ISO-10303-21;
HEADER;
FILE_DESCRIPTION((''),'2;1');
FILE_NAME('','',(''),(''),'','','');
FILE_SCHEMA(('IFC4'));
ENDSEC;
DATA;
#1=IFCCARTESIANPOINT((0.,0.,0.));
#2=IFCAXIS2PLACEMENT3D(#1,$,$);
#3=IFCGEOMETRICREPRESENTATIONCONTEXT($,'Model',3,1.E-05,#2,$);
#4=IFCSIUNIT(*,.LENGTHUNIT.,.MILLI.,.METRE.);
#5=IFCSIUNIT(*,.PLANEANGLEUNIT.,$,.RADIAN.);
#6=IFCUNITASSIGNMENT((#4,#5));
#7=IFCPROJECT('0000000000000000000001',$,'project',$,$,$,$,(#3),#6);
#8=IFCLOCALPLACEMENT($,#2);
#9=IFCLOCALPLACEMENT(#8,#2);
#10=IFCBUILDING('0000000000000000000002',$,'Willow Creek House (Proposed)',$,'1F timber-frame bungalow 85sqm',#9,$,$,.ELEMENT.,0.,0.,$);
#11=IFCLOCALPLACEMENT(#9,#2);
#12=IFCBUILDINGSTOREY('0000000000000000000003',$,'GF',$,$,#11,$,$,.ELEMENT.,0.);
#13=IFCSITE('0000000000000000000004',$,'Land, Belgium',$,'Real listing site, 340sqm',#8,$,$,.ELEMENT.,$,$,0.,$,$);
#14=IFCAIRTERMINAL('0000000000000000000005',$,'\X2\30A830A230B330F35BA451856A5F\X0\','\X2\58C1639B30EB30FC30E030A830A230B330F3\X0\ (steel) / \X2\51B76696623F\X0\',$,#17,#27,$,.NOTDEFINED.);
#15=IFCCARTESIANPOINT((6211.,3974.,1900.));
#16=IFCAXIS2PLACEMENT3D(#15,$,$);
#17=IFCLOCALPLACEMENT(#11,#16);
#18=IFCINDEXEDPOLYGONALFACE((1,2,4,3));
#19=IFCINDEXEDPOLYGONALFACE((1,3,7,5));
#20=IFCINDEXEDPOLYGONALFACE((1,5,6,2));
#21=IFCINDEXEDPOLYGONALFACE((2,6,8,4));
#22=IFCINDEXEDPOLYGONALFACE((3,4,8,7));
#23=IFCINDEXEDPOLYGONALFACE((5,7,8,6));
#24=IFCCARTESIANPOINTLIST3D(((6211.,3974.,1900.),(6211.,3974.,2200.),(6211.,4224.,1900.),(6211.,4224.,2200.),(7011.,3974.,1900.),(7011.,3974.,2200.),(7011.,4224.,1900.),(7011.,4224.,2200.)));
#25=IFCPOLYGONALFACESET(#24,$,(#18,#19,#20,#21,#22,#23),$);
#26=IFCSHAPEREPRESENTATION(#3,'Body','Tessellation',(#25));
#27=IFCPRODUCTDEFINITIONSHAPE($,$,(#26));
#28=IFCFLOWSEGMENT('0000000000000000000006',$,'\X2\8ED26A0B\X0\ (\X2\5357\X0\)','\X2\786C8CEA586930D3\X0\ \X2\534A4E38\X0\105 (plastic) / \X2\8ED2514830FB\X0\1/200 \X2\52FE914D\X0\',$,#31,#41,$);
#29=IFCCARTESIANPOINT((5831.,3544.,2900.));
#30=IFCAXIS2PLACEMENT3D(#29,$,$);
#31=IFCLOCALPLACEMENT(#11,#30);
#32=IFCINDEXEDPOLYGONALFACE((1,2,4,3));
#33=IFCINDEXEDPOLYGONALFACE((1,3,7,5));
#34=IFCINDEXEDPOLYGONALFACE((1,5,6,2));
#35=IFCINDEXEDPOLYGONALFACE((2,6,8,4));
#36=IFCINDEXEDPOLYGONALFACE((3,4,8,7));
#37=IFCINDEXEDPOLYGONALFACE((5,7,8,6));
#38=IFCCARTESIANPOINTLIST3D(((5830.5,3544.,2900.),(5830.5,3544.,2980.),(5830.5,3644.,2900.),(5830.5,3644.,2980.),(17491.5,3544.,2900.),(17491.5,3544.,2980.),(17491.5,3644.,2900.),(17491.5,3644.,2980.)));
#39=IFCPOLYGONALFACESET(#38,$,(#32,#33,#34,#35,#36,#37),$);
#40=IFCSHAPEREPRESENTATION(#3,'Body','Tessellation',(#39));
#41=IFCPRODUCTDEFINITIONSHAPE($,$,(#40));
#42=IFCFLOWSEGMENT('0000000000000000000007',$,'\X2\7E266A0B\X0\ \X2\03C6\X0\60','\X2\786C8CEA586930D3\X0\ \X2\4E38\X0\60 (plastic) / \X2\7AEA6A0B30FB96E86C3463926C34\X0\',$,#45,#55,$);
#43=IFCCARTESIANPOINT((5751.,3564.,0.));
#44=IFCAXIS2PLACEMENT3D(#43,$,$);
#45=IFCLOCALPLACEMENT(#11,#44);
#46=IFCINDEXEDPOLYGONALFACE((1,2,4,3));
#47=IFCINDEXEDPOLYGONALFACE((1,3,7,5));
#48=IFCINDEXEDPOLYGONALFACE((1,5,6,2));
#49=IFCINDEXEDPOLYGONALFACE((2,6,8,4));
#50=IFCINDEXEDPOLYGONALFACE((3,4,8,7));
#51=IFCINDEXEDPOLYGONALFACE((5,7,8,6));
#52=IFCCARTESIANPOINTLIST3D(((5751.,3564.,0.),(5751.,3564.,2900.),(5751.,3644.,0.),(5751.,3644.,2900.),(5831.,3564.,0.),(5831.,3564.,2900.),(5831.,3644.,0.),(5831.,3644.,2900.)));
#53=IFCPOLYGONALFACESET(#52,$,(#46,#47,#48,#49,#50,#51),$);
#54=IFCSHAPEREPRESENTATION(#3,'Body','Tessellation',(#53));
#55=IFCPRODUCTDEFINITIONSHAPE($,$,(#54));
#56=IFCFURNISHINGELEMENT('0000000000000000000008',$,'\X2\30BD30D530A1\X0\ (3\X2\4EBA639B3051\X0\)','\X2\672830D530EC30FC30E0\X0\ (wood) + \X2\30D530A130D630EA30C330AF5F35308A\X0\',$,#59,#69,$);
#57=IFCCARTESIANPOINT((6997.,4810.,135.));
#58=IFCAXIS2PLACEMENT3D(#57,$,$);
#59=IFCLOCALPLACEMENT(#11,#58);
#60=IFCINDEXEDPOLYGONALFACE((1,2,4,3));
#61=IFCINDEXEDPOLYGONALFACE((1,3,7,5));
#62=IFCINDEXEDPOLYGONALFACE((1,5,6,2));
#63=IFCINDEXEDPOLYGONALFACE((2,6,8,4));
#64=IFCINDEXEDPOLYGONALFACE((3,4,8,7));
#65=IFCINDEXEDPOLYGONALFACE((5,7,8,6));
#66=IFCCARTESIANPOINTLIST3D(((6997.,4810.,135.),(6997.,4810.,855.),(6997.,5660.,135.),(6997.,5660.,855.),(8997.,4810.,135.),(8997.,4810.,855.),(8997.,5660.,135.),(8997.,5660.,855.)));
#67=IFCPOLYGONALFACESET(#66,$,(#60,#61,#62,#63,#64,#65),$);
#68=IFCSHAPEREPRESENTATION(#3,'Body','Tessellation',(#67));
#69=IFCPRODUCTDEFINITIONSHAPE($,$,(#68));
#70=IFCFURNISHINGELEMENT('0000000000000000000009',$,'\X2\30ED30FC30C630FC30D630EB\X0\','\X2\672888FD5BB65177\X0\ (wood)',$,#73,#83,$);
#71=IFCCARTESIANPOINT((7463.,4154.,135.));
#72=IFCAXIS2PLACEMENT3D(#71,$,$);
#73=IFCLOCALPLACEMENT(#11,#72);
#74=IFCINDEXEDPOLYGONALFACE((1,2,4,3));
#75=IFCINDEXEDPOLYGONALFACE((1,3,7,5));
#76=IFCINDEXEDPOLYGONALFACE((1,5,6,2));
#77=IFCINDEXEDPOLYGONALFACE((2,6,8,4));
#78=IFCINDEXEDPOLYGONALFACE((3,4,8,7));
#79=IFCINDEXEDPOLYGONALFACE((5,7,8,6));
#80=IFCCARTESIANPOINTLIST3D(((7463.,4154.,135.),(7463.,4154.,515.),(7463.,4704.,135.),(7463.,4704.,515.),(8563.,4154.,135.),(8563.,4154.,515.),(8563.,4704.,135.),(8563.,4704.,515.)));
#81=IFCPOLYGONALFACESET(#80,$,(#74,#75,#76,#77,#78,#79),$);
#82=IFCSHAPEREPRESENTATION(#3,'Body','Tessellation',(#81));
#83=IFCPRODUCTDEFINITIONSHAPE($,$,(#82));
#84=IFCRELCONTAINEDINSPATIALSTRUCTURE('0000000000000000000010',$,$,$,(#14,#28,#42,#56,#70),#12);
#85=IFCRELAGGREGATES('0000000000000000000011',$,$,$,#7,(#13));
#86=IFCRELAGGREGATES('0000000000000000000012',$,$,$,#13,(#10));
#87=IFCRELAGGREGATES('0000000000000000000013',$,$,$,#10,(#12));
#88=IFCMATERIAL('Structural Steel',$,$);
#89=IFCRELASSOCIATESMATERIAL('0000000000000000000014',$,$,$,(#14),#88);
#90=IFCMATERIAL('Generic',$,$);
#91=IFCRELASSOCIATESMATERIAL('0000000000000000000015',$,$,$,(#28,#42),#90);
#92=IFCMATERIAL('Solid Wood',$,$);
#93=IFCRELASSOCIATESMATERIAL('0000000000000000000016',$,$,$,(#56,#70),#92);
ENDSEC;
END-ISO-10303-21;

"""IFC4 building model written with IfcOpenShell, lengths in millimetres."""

from ifc_helpers import new_model, si_unit, frame, frame_2d, origin, place, context, project, spatial, rectangle, extrude, material, element, save


model = new_model("IFC4")

# Units and contexts
model_context = context("Model", 3, precision=1e-05, world=origin())
ifc_project = project(units=[si_unit("LENGTHUNIT", "METRE", prefix="MILLI"), si_unit("PLANEANGLEUNIT", "RADIAN")], contexts=[model_context])

# Site, building, storey
site_placement = place(None, origin())
site = spatial("IfcSite", under=ifc_project, at=site_placement, Name="Land, Belgium", ObjectType="Real listing site, 340sqm", CompositionType="ELEMENT", RefElevation=0.0)
building_placement = place(site_placement, origin())
building = spatial("IfcBuilding", under=site, at=building_placement, Name="Willow Creek House (Proposed)", ObjectType="1F timber-frame bungalow 85sqm", CompositionType="ELEMENT", ElevationOfRefHeight=0.0, ElevationOfTerrain=0.0)
storey_placement = place(building_placement, origin())
storey = spatial("IfcBuildingStorey", under=building, at=storey_placement, Name="GF", CompositionType="ELEMENT", Elevation=0.0)

# Shared definitions
ifc_material_1 = material(Name="Solid Wood")

# Shared definitions
ifc_material_2 = material(Name="Structural Steel")

# Shared definitions
ifc_material_3 = material(Name="Generic")

# Air terminal
air_terminal_placement = place(storey_placement, frame((6211.0, 3974.0, 1900.0)))
element("IfcAirTerminal", 1, at=air_terminal_placement, inside=storey, material=ifc_material_2, Name="エアコン室内機", Description="壁掛ルームエアコン (steel) / 冷暖房", PredefinedType="NOTDEFINED", context=model_context, shape_type="SweptSolid", body=[
    extrude(rectangle(XDim=800.0, YDim=250.0, at=frame_2d((400.0, 125.0))), frame((6211.0, 3974.0, 1900.0)), (0.0, 0.0, 1.0), 300.0),
])

# Flow segments
flow_segment_1_placement = place(storey_placement, frame((5831.0, 3544.0, 2900.0)))
element("IfcFlowSegment", 2, at=flow_segment_1_placement, inside=storey, material=ifc_material_3, Name="軒樋 (南)", Description="硬質塩ビ 半丸105 (plastic) / 軒先・1/200 勾配", context=model_context, shape_type="SweptSolid", body=[
    extrude(rectangle(XDim=11661.0, YDim=100.0, at=frame_2d((5830.0, 50.0))), frame((5831.0, 3544.0, 2900.0)), (0.0, 0.0, 1.0), 80.0),
])
flow_segment_2_placement = place(storey_placement, frame((5751.0, 3564.0, 0.0)))
element("IfcFlowSegment", 3, at=flow_segment_2_placement, inside=storey, material=ifc_material_3, Name="縦樋 φ60", Description="硬質塩ビ 丸60 (plastic) / 竪樋・雨水排水", context=model_context, shape_type="SweptSolid", body=[
    extrude(rectangle(XDim=80.0, YDim=80.0, at=frame_2d((40.0, 40.0))), frame((5751.0, 3564.0, 0.0)), (0.0, 0.0, 1.0), 2900.0),
])

# Furnishing elements
furnishing_1_placement = place(storey_placement, frame((6997.0, 4810.0, 135.0)))
element("IfcFurnishingElement", 4, at=furnishing_1_placement, inside=storey, material=ifc_material_1, Name="ソファ (3人掛け)", Description="木フレーム (wood) + ファブリック張り", context=model_context, shape_type="SweptSolid", body=[
    extrude(rectangle(XDim=2000.0, YDim=850.0, at=frame_2d((1000.0, 425.0))), frame((6997.0, 4810.0, 135.0)), (0.0, 0.0, 1.0), 720.0),
])
furnishing_2_placement = place(storey_placement, frame((7463.0, 4154.0, 135.0)))
element("IfcFurnishingElement", 5, at=furnishing_2_placement, inside=storey, material=ifc_material_1, Name="ローテーブル", Description="木製家具 (wood)", context=model_context, shape_type="SweptSolid", body=[
    extrude(rectangle(XDim=1100.0, YDim=550.0, at=frame_2d((550.0, 275.0))), frame((7463.0, 4154.0, 135.0)), (0.0, 0.0, 1.0), 380.0),
])

save(model, "model.ifc")
